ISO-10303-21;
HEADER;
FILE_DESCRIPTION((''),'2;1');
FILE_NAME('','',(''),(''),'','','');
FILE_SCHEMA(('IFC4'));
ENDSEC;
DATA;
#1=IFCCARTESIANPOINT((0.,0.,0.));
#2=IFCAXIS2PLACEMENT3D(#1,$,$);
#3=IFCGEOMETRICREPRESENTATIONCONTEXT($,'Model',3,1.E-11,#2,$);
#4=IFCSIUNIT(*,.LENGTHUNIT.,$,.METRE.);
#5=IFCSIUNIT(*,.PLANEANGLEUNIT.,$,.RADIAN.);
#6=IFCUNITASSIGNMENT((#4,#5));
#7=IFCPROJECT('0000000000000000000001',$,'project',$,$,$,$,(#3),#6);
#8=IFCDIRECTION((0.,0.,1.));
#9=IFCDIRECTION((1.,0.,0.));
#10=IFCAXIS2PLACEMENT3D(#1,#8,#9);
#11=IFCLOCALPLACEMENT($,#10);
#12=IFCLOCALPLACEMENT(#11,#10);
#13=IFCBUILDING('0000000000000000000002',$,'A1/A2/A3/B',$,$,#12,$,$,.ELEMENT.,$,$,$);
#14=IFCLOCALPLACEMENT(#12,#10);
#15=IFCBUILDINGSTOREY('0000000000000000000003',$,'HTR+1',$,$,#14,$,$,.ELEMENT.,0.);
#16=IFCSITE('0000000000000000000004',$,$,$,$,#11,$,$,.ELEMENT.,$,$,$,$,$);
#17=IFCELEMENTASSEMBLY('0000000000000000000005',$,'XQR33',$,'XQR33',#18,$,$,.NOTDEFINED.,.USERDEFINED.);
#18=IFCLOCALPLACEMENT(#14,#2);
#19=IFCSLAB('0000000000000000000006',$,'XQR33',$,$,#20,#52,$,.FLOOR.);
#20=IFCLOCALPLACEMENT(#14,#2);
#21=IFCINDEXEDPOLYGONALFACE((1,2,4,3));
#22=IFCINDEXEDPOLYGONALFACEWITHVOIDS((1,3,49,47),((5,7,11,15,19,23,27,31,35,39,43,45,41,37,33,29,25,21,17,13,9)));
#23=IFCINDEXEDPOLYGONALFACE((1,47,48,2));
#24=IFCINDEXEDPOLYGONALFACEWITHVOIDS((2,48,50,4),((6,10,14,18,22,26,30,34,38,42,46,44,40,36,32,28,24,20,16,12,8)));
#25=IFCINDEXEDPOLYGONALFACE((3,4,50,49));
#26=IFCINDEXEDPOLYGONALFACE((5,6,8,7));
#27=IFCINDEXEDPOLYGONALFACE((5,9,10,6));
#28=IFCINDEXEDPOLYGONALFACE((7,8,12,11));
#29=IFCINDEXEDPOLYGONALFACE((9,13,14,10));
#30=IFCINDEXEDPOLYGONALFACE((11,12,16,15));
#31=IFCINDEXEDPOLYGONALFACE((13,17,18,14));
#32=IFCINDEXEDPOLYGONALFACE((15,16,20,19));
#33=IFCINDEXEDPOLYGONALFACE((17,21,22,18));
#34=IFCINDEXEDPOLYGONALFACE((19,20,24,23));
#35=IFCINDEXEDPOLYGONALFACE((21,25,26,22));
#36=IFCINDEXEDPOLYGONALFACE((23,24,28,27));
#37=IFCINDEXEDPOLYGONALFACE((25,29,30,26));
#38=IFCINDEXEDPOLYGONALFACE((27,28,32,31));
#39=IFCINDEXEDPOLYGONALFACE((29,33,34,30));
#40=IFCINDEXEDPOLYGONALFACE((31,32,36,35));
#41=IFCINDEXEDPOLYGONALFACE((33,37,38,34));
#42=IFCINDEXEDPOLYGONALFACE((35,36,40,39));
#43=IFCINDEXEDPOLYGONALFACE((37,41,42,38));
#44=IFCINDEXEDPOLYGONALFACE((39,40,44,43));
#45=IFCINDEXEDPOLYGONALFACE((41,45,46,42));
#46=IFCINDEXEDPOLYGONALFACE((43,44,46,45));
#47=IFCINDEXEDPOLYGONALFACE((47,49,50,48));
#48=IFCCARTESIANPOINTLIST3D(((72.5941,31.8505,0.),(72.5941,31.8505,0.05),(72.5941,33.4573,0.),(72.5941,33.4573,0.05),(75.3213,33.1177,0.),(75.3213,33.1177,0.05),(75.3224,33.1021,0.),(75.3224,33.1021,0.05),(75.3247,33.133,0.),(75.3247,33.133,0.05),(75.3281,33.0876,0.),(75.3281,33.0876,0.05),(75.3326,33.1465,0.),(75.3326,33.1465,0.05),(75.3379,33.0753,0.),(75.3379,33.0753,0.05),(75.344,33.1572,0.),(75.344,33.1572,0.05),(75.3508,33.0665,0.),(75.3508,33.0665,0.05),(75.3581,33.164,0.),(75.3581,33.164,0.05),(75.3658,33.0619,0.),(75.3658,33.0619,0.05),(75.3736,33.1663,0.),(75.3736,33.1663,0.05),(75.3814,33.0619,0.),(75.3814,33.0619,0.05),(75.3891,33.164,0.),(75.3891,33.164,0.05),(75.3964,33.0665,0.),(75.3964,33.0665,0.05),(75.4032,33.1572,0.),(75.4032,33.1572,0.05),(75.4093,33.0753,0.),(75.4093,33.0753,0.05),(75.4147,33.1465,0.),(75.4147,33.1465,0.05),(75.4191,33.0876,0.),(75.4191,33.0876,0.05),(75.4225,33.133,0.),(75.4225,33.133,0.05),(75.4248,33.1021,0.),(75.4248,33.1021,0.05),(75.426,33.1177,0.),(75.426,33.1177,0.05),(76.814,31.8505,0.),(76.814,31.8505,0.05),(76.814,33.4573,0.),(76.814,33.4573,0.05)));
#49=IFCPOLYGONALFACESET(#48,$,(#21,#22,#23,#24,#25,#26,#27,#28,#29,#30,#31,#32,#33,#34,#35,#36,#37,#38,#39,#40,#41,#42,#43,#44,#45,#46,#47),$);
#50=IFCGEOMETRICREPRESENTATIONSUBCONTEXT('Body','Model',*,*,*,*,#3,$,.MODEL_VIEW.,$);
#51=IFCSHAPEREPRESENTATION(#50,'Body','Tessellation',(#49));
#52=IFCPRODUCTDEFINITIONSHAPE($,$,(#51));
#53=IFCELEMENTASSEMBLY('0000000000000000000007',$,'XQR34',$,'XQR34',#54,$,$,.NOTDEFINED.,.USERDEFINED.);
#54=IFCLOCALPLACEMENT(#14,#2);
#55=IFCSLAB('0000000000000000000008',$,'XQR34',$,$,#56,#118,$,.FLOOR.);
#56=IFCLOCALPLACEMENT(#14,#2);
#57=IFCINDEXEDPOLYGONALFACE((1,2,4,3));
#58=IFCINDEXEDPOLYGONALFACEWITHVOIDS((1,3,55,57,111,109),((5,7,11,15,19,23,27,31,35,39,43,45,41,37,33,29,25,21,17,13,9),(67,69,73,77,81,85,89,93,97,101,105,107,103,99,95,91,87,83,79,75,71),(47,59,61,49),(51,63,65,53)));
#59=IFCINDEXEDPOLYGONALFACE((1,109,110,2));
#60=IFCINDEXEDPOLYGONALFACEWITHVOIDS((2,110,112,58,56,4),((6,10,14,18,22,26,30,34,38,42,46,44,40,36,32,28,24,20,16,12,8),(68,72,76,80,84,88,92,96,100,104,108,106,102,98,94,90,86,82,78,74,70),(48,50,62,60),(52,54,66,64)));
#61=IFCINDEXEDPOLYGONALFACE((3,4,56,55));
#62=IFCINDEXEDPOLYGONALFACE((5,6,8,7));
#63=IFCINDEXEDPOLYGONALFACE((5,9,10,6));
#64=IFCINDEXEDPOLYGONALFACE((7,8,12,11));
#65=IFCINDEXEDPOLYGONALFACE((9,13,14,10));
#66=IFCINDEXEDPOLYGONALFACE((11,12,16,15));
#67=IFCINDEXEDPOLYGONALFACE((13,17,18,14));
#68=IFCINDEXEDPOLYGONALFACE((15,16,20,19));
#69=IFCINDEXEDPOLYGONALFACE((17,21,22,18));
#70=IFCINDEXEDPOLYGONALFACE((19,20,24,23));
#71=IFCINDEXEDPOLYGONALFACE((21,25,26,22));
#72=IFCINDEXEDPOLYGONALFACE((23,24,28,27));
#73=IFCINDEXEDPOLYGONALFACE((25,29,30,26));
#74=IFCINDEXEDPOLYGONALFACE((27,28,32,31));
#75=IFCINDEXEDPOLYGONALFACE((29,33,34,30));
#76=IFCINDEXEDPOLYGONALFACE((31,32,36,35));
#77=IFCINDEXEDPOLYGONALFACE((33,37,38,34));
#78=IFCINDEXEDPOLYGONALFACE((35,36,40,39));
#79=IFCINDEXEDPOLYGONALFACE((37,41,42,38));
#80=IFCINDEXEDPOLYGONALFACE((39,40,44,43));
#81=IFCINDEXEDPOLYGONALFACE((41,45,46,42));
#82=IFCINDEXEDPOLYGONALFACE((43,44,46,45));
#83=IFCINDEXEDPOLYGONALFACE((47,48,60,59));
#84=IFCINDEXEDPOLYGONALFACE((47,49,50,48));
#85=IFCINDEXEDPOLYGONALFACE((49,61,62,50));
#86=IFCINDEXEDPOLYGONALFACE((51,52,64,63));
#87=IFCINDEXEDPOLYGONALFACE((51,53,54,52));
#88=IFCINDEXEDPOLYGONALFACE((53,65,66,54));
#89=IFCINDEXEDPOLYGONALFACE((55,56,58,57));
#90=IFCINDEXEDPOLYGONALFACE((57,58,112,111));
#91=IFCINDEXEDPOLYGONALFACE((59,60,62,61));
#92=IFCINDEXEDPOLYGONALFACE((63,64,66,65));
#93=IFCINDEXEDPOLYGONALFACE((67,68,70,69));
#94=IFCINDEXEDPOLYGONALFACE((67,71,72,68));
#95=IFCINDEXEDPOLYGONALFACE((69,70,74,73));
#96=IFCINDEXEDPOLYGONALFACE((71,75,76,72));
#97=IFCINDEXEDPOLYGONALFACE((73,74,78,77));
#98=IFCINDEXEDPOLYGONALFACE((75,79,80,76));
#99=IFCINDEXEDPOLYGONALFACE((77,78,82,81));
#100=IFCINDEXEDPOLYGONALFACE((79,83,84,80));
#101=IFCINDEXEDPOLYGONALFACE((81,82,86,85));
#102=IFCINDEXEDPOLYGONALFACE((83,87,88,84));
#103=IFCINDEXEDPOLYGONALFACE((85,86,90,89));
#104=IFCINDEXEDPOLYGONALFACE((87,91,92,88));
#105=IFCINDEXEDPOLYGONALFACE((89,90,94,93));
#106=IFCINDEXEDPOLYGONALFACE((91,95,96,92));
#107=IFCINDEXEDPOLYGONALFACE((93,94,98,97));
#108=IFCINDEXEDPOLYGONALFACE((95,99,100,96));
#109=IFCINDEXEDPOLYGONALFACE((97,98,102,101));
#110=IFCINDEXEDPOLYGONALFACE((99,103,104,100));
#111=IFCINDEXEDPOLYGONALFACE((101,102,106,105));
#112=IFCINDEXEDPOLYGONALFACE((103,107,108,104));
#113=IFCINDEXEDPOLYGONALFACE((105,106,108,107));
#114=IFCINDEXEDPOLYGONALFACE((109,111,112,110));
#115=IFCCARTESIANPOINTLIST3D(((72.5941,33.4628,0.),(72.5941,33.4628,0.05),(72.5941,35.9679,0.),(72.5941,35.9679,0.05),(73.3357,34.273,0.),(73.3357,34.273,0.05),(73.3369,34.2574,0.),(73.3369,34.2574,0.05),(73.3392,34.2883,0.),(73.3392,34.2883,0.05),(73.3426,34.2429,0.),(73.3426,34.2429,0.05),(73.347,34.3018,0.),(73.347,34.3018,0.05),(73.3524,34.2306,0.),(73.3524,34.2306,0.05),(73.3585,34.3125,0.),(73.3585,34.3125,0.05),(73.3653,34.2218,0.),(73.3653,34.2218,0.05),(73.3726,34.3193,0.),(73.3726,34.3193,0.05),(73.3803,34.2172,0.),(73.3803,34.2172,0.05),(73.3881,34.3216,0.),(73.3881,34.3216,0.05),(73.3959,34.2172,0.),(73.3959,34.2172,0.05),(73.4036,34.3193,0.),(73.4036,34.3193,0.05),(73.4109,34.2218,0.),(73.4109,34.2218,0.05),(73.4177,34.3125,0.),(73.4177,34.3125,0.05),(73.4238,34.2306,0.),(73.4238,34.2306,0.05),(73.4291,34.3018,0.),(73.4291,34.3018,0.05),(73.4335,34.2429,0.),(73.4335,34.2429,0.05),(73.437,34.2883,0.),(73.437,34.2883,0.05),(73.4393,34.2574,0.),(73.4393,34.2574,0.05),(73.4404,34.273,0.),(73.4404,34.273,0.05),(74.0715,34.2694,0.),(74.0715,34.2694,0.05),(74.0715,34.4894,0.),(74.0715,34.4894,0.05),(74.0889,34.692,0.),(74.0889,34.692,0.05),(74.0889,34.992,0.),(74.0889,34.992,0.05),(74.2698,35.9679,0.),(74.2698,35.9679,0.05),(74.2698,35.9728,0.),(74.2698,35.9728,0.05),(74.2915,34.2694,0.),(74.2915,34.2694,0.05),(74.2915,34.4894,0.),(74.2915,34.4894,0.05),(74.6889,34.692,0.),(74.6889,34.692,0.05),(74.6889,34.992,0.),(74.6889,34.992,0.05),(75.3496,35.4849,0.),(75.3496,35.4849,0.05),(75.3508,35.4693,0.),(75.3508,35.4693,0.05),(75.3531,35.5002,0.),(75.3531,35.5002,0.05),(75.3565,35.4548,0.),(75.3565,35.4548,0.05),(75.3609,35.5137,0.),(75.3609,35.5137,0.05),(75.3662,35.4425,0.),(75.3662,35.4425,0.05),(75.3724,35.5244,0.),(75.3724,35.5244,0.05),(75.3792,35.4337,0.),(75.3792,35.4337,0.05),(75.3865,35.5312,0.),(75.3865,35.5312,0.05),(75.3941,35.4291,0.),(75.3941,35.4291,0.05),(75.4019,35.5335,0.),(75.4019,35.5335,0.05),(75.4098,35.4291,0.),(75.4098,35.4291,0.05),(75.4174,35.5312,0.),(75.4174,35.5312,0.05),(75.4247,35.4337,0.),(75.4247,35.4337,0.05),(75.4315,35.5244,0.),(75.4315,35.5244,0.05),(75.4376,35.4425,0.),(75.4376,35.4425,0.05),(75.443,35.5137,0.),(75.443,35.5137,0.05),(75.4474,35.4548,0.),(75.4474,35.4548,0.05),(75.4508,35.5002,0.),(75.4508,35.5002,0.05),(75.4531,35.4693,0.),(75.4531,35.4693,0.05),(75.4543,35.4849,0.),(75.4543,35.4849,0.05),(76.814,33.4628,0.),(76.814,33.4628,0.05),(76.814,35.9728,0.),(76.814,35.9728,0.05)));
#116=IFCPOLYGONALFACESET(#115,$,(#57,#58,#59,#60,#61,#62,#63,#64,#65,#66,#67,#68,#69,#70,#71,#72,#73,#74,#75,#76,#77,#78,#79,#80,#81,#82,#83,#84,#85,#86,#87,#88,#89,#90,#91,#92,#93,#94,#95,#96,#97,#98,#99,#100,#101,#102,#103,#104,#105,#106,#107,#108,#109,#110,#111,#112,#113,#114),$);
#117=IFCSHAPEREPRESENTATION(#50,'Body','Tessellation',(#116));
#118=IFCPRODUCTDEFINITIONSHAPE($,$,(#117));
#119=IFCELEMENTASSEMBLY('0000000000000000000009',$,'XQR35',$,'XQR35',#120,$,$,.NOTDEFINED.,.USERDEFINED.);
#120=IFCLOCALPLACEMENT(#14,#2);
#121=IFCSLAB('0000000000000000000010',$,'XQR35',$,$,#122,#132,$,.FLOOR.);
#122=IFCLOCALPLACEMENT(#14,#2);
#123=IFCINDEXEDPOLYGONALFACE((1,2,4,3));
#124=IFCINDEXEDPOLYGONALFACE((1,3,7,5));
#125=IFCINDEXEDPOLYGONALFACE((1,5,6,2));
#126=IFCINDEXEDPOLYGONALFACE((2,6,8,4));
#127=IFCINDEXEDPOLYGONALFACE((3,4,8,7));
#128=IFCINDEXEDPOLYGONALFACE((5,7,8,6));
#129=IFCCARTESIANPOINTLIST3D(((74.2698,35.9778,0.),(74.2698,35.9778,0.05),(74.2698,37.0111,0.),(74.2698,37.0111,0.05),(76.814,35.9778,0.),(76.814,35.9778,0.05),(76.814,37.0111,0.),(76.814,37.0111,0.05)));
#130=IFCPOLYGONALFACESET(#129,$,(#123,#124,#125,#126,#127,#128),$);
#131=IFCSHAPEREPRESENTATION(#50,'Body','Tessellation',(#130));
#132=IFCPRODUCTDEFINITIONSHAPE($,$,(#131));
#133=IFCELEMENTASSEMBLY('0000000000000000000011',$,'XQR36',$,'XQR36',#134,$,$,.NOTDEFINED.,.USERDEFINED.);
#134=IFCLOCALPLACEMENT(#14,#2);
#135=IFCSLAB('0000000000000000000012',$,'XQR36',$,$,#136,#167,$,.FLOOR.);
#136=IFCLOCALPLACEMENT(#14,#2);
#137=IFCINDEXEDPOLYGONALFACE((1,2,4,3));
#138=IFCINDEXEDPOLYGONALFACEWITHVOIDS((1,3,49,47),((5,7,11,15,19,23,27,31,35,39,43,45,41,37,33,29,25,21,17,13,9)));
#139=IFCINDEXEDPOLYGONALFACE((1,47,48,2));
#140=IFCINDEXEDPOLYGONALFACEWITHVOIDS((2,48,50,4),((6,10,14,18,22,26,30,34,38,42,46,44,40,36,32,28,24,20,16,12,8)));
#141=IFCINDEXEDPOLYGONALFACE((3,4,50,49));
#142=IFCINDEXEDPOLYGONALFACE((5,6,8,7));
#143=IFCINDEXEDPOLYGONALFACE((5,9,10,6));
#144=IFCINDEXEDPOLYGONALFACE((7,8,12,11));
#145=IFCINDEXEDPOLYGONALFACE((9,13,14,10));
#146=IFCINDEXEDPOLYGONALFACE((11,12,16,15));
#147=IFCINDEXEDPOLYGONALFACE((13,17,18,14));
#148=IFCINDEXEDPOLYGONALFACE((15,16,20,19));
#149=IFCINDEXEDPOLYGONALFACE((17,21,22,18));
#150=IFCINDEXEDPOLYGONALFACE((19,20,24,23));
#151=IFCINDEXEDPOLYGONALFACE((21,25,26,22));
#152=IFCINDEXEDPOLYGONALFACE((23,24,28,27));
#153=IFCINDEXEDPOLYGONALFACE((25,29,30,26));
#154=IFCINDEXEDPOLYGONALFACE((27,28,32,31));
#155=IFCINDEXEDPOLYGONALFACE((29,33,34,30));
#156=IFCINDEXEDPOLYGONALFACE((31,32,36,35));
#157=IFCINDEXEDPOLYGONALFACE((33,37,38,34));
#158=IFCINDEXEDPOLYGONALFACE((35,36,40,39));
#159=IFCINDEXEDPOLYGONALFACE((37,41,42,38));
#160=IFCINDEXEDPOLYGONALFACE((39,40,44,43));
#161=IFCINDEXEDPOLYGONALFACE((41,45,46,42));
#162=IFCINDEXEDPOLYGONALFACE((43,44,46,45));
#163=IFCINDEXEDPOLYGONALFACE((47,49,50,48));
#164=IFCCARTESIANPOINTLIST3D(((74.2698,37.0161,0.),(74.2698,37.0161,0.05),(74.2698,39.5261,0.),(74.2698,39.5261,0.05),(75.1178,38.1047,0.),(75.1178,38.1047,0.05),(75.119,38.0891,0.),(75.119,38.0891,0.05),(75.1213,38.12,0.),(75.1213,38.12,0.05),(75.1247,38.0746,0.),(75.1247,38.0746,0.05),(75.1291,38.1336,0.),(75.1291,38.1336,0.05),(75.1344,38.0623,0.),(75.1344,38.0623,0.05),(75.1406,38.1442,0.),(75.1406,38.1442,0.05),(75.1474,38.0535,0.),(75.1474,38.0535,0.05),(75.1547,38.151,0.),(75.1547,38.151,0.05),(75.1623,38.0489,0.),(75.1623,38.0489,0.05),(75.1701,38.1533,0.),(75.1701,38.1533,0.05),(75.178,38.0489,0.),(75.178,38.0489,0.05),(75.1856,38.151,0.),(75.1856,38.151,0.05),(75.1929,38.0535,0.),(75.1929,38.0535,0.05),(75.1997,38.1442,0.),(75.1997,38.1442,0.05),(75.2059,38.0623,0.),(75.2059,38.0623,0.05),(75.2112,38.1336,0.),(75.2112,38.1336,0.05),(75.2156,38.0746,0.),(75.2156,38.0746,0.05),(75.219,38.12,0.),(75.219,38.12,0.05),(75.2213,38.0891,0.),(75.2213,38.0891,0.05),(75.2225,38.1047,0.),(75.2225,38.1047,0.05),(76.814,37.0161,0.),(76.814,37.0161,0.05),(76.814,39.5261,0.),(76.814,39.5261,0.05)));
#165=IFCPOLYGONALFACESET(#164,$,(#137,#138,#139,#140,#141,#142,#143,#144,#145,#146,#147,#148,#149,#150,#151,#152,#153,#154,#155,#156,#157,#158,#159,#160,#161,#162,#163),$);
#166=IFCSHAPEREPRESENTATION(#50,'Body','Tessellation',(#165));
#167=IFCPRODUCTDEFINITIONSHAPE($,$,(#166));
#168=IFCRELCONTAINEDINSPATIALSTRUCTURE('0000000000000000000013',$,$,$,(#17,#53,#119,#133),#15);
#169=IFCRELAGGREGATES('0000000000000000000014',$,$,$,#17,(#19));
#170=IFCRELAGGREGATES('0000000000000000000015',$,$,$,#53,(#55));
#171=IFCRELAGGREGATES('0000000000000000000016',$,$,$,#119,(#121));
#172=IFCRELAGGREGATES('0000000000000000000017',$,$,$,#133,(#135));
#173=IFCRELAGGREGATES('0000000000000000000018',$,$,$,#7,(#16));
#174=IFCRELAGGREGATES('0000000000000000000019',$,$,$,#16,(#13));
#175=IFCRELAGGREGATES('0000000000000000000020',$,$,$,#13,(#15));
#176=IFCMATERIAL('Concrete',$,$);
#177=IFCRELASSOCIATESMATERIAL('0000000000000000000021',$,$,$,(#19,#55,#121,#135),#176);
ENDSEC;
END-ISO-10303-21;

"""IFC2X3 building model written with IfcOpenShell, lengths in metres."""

from ifc_helpers import new_model, si_unit, frame, origin, origin_with_axes, origin_2d_with_axis, place, context, subcontext, project, spatial, polyline, circle, outline, extrude, material, element, aggregate, save


model = new_model("IFC2X3")

# Units and contexts
model_context = context("Model", 3, precision=1e-11, world=origin())
body_context = subcontext(model_context, "Body", "Model", "MODEL_VIEW")
ifc_project = project(units=[si_unit("LENGTHUNIT", "METRE"), si_unit("PLANEANGLEUNIT", "RADIAN")], contexts=[model_context])

# Site, building, storey
site_placement = place(None, origin_with_axes())
site = spatial("IfcSite", under=ifc_project, at=site_placement, CompositionType="ELEMENT")
building_placement = place(site_placement, origin_with_axes())
building = spatial("IfcBuilding", under=site, at=building_placement, Name="A1/A2/A3/B", CompositionType="ELEMENT")
storey_placement = place(building_placement, origin_with_axes())
storey = spatial("IfcBuildingStorey", under=building, at=storey_placement, Name="HTR+1", CompositionType="ELEMENT", Elevation=0.0)

# Element assembly, slab, opening
assembly_1_placement = place(storey_placement, origin_with_axes())
assembly_1 = element("IfcElementAssembly", 1, at=assembly_1_placement, inside=storey, Name="XQR33", ObjectType="XQR33", AssemblyPlace="NOTDEFINED", PredefinedType="USERDEFINED")
ifc_material = material(Name="Concrete")
slab_1_placement = place(assembly_1_placement, frame((72.5941, 31.8505, 0.0), z_axis=(0.0, 0.0, 1.0), x_axis=(1.0, 0.0, 0.0)))
slab_1 = element("IfcSlab", 2, at=slab_1_placement, material=ifc_material, Name="XQR33", PredefinedType="FLOOR", context=body_context, shape_type="SweptSolid", body=[
    extrude(outline(polyline([(0.0, 0.0), (0.0, -4.2198), (1.6068, -4.2198), (1.6068, 0.0), (0.0, 0.0)])), frame((0.0, 0.0, 0.0), z_axis=(0.0, 0.0, 1.0), x_axis=(0.0, 1.0, 0.0)), (0.0, 0.0, 1.0), 0.05),
])
opening_1_placement = place(slab_1_placement, frame((2.7795, 1.2633, 0.0), z_axis=(0.0, 0.0, 1.0), x_axis=(1.0, 0.0, 0.0)))
element("IfcOpeningElement", 3, at=opening_1_placement, cuts=slab_1, ObjectType="Opening", context=body_context, shape_type="SweptSolid", body=[
    extrude(circle(Radius=0.0525, at=origin_2d_with_axis()), frame((0.0, 0.0, 0.0), z_axis=(0.0, 0.0, 1.0), x_axis=(0.0, 1.0, 0.0)), (0.0, 0.0, 1.0), 0.05),
])

# Element assembly, slab, openings
assembly_2_placement = place(storey_placement, origin_with_axes())
assembly_2 = element("IfcElementAssembly", 4, at=assembly_2_placement, inside=storey, Name="XQR34", ObjectType="XQR34", AssemblyPlace="NOTDEFINED", PredefinedType="USERDEFINED")
slab_2_placement = place(assembly_2_placement, frame((72.5941, 33.4628, 0.0), z_axis=(0.0, 0.0, 1.0), x_axis=(1.0, 0.0, 0.0)))
slab_2 = element("IfcSlab", 5, at=slab_2_placement, material=ifc_material, Name="XQR34", PredefinedType="FLOOR", context=body_context, shape_type="SweptSolid", body=[
    extrude(outline(polyline([(0.0, 0.0), (0.0, -4.2198), (2.51, -4.2198), (2.51, -1.6757), (2.5051, -1.6757), (2.5051, 0.0), (0.0, 0.0)])), frame((0.0, 0.0, 0.0), z_axis=(0.0, 0.0, 1.0), x_axis=(0.0, 1.0, 0.0)), (0.0, 0.0, 1.0), 0.05),
])
opening_2_placement = place(slab_2_placement, origin_with_axes())
element("IfcOpeningElement", 6, at=opening_2_placement, cuts=slab_2, ObjectType="Opening", context=body_context, shape_type="SweptSolid", body=[
    extrude(outline(polyline([(1.2292, -1.4948), (1.2292, -2.0948), (1.5292, -2.0948), (1.5292, -1.4948), (1.2292, -1.4948)])), frame((0.0, 0.0, 0.0), z_axis=(0.0, 0.0, 1.0), x_axis=(0.0, 1.0, 0.0)), (0.0, 0.0, 1.0), 0.05),
])
opening_3_placement = place(slab_2_placement, origin_with_axes())
element("IfcOpeningElement", 7, at=opening_3_placement, cuts=slab_2, ObjectType="Opening", context=body_context, shape_type="SweptSolid", body=[
    extrude(outline(polyline([(0.8066, -1.4774), (0.8066, -1.6974), (1.0266, -1.6974), (1.0266, -1.4774), (0.8066, -1.4774)])), frame((0.0, 0.0, 0.0), z_axis=(0.0, 0.0, 1.0), x_axis=(0.0, 1.0, 0.0)), (0.0, 0.0, 1.0), 0.05),
])
opening_4_placement = place(slab_2_placement, frame((2.8078, 2.0182, 0.0), z_axis=(0.0, 0.0, 1.0), x_axis=(1.0, 0.0, 0.0)))
element("IfcOpeningElement", 8, at=opening_4_placement, cuts=slab_2, ObjectType="Opening", context=body_context, shape_type="SweptSolid", body=[
    extrude(circle(Radius=0.0525, at=origin_2d_with_axis()), frame((0.0, 0.0, 0.0), z_axis=(0.0, 0.0, 1.0), x_axis=(0.0, 1.0, 0.0)), (0.0, 0.0, 1.0), 0.05),
])
opening_5_placement = place(slab_2_placement, frame((0.7939, 0.8063, 0.0), z_axis=(0.0, 0.0, 1.0), x_axis=(1.0, 0.0, 0.0)))
element("IfcOpeningElement", 9, at=opening_5_placement, cuts=slab_2, ObjectType="Opening", context=body_context, shape_type="SweptSolid", body=[
    extrude(circle(Radius=0.0525, at=origin_2d_with_axis()), frame((0.0, 0.0, 0.0), z_axis=(0.0, 0.0, 1.0), x_axis=(0.0, 1.0, 0.0)), (0.0, 0.0, 1.0), 0.05),
])

# Element assembly, slab
assembly_3_placement = place(storey_placement, origin_with_axes())
assembly_3 = element("IfcElementAssembly", 10, at=assembly_3_placement, inside=storey, Name="XQR35", ObjectType="XQR35", AssemblyPlace="NOTDEFINED", PredefinedType="USERDEFINED")
slab_3_placement = place(assembly_3_placement, frame((74.2698, 35.9778, 0.0), z_axis=(0.0, 0.0, 1.0), x_axis=(1.0, 0.0, 0.0)))
slab_3 = element("IfcSlab", 11, at=slab_3_placement, material=ifc_material, Name="XQR35", PredefinedType="FLOOR", context=body_context, shape_type="SweptSolid", body=[
    extrude(outline(polyline([(0.0, 0.0), (0.0, -2.5442), (1.0333, -2.5442), (1.0333, 0.0), (0.0, 0.0)])), frame((0.0, 0.0, 0.0), z_axis=(0.0, 0.0, 1.0), x_axis=(0.0, 1.0, 0.0)), (0.0, 0.0, 1.0), 0.05),
])

# Element assembly, slab, opening
assembly_4_placement = place(storey_placement, origin_with_axes())
assembly_4 = element("IfcElementAssembly", 12, at=assembly_4_placement, inside=storey, Name="XQR36", ObjectType="XQR36", AssemblyPlace="NOTDEFINED", PredefinedType="USERDEFINED")
slab_4_placement = place(assembly_4_placement, frame((74.2698, 37.0161, 0.0), z_axis=(0.0, 0.0, 1.0), x_axis=(1.0, 0.0, 0.0)))
slab_4 = element("IfcSlab", 13, at=slab_4_placement, material=ifc_material, Name="XQR36", PredefinedType="FLOOR", context=body_context, shape_type="SweptSolid", body=[
    extrude(outline(polyline([(0.0, 0.0), (0.0, -2.5442), (2.51, -2.5442), (2.51, 0.0), (0.0, 0.0)])), frame((0.0, 0.0, 0.0), z_axis=(0.0, 0.0, 1.0), x_axis=(0.0, 1.0, 0.0)), (0.0, 0.0, 1.0), 0.05),
])
opening_6_placement = place(slab_4_placement, frame((0.9004, 1.0847, 0.0), z_axis=(0.0, 0.0, 1.0), x_axis=(1.0, 0.0, 0.0)))
element("IfcOpeningElement", 14, at=opening_6_placement, cuts=slab_4, ObjectType="Opening", context=body_context, shape_type="SweptSolid", body=[
    extrude(circle(Radius=0.0525, at=origin_2d_with_axis()), frame((0.0, 0.0, 0.0), z_axis=(0.0, 0.0, 1.0), x_axis=(0.0, 1.0, 0.0)), (0.0, 0.0, 1.0), 0.05),
])

aggregate(assembly_1, [slab_1])

aggregate(assembly_2, [slab_2])
aggregate(assembly_3, [slab_3])

aggregate(assembly_4, [slab_4])

save(model, "model.ifc")
